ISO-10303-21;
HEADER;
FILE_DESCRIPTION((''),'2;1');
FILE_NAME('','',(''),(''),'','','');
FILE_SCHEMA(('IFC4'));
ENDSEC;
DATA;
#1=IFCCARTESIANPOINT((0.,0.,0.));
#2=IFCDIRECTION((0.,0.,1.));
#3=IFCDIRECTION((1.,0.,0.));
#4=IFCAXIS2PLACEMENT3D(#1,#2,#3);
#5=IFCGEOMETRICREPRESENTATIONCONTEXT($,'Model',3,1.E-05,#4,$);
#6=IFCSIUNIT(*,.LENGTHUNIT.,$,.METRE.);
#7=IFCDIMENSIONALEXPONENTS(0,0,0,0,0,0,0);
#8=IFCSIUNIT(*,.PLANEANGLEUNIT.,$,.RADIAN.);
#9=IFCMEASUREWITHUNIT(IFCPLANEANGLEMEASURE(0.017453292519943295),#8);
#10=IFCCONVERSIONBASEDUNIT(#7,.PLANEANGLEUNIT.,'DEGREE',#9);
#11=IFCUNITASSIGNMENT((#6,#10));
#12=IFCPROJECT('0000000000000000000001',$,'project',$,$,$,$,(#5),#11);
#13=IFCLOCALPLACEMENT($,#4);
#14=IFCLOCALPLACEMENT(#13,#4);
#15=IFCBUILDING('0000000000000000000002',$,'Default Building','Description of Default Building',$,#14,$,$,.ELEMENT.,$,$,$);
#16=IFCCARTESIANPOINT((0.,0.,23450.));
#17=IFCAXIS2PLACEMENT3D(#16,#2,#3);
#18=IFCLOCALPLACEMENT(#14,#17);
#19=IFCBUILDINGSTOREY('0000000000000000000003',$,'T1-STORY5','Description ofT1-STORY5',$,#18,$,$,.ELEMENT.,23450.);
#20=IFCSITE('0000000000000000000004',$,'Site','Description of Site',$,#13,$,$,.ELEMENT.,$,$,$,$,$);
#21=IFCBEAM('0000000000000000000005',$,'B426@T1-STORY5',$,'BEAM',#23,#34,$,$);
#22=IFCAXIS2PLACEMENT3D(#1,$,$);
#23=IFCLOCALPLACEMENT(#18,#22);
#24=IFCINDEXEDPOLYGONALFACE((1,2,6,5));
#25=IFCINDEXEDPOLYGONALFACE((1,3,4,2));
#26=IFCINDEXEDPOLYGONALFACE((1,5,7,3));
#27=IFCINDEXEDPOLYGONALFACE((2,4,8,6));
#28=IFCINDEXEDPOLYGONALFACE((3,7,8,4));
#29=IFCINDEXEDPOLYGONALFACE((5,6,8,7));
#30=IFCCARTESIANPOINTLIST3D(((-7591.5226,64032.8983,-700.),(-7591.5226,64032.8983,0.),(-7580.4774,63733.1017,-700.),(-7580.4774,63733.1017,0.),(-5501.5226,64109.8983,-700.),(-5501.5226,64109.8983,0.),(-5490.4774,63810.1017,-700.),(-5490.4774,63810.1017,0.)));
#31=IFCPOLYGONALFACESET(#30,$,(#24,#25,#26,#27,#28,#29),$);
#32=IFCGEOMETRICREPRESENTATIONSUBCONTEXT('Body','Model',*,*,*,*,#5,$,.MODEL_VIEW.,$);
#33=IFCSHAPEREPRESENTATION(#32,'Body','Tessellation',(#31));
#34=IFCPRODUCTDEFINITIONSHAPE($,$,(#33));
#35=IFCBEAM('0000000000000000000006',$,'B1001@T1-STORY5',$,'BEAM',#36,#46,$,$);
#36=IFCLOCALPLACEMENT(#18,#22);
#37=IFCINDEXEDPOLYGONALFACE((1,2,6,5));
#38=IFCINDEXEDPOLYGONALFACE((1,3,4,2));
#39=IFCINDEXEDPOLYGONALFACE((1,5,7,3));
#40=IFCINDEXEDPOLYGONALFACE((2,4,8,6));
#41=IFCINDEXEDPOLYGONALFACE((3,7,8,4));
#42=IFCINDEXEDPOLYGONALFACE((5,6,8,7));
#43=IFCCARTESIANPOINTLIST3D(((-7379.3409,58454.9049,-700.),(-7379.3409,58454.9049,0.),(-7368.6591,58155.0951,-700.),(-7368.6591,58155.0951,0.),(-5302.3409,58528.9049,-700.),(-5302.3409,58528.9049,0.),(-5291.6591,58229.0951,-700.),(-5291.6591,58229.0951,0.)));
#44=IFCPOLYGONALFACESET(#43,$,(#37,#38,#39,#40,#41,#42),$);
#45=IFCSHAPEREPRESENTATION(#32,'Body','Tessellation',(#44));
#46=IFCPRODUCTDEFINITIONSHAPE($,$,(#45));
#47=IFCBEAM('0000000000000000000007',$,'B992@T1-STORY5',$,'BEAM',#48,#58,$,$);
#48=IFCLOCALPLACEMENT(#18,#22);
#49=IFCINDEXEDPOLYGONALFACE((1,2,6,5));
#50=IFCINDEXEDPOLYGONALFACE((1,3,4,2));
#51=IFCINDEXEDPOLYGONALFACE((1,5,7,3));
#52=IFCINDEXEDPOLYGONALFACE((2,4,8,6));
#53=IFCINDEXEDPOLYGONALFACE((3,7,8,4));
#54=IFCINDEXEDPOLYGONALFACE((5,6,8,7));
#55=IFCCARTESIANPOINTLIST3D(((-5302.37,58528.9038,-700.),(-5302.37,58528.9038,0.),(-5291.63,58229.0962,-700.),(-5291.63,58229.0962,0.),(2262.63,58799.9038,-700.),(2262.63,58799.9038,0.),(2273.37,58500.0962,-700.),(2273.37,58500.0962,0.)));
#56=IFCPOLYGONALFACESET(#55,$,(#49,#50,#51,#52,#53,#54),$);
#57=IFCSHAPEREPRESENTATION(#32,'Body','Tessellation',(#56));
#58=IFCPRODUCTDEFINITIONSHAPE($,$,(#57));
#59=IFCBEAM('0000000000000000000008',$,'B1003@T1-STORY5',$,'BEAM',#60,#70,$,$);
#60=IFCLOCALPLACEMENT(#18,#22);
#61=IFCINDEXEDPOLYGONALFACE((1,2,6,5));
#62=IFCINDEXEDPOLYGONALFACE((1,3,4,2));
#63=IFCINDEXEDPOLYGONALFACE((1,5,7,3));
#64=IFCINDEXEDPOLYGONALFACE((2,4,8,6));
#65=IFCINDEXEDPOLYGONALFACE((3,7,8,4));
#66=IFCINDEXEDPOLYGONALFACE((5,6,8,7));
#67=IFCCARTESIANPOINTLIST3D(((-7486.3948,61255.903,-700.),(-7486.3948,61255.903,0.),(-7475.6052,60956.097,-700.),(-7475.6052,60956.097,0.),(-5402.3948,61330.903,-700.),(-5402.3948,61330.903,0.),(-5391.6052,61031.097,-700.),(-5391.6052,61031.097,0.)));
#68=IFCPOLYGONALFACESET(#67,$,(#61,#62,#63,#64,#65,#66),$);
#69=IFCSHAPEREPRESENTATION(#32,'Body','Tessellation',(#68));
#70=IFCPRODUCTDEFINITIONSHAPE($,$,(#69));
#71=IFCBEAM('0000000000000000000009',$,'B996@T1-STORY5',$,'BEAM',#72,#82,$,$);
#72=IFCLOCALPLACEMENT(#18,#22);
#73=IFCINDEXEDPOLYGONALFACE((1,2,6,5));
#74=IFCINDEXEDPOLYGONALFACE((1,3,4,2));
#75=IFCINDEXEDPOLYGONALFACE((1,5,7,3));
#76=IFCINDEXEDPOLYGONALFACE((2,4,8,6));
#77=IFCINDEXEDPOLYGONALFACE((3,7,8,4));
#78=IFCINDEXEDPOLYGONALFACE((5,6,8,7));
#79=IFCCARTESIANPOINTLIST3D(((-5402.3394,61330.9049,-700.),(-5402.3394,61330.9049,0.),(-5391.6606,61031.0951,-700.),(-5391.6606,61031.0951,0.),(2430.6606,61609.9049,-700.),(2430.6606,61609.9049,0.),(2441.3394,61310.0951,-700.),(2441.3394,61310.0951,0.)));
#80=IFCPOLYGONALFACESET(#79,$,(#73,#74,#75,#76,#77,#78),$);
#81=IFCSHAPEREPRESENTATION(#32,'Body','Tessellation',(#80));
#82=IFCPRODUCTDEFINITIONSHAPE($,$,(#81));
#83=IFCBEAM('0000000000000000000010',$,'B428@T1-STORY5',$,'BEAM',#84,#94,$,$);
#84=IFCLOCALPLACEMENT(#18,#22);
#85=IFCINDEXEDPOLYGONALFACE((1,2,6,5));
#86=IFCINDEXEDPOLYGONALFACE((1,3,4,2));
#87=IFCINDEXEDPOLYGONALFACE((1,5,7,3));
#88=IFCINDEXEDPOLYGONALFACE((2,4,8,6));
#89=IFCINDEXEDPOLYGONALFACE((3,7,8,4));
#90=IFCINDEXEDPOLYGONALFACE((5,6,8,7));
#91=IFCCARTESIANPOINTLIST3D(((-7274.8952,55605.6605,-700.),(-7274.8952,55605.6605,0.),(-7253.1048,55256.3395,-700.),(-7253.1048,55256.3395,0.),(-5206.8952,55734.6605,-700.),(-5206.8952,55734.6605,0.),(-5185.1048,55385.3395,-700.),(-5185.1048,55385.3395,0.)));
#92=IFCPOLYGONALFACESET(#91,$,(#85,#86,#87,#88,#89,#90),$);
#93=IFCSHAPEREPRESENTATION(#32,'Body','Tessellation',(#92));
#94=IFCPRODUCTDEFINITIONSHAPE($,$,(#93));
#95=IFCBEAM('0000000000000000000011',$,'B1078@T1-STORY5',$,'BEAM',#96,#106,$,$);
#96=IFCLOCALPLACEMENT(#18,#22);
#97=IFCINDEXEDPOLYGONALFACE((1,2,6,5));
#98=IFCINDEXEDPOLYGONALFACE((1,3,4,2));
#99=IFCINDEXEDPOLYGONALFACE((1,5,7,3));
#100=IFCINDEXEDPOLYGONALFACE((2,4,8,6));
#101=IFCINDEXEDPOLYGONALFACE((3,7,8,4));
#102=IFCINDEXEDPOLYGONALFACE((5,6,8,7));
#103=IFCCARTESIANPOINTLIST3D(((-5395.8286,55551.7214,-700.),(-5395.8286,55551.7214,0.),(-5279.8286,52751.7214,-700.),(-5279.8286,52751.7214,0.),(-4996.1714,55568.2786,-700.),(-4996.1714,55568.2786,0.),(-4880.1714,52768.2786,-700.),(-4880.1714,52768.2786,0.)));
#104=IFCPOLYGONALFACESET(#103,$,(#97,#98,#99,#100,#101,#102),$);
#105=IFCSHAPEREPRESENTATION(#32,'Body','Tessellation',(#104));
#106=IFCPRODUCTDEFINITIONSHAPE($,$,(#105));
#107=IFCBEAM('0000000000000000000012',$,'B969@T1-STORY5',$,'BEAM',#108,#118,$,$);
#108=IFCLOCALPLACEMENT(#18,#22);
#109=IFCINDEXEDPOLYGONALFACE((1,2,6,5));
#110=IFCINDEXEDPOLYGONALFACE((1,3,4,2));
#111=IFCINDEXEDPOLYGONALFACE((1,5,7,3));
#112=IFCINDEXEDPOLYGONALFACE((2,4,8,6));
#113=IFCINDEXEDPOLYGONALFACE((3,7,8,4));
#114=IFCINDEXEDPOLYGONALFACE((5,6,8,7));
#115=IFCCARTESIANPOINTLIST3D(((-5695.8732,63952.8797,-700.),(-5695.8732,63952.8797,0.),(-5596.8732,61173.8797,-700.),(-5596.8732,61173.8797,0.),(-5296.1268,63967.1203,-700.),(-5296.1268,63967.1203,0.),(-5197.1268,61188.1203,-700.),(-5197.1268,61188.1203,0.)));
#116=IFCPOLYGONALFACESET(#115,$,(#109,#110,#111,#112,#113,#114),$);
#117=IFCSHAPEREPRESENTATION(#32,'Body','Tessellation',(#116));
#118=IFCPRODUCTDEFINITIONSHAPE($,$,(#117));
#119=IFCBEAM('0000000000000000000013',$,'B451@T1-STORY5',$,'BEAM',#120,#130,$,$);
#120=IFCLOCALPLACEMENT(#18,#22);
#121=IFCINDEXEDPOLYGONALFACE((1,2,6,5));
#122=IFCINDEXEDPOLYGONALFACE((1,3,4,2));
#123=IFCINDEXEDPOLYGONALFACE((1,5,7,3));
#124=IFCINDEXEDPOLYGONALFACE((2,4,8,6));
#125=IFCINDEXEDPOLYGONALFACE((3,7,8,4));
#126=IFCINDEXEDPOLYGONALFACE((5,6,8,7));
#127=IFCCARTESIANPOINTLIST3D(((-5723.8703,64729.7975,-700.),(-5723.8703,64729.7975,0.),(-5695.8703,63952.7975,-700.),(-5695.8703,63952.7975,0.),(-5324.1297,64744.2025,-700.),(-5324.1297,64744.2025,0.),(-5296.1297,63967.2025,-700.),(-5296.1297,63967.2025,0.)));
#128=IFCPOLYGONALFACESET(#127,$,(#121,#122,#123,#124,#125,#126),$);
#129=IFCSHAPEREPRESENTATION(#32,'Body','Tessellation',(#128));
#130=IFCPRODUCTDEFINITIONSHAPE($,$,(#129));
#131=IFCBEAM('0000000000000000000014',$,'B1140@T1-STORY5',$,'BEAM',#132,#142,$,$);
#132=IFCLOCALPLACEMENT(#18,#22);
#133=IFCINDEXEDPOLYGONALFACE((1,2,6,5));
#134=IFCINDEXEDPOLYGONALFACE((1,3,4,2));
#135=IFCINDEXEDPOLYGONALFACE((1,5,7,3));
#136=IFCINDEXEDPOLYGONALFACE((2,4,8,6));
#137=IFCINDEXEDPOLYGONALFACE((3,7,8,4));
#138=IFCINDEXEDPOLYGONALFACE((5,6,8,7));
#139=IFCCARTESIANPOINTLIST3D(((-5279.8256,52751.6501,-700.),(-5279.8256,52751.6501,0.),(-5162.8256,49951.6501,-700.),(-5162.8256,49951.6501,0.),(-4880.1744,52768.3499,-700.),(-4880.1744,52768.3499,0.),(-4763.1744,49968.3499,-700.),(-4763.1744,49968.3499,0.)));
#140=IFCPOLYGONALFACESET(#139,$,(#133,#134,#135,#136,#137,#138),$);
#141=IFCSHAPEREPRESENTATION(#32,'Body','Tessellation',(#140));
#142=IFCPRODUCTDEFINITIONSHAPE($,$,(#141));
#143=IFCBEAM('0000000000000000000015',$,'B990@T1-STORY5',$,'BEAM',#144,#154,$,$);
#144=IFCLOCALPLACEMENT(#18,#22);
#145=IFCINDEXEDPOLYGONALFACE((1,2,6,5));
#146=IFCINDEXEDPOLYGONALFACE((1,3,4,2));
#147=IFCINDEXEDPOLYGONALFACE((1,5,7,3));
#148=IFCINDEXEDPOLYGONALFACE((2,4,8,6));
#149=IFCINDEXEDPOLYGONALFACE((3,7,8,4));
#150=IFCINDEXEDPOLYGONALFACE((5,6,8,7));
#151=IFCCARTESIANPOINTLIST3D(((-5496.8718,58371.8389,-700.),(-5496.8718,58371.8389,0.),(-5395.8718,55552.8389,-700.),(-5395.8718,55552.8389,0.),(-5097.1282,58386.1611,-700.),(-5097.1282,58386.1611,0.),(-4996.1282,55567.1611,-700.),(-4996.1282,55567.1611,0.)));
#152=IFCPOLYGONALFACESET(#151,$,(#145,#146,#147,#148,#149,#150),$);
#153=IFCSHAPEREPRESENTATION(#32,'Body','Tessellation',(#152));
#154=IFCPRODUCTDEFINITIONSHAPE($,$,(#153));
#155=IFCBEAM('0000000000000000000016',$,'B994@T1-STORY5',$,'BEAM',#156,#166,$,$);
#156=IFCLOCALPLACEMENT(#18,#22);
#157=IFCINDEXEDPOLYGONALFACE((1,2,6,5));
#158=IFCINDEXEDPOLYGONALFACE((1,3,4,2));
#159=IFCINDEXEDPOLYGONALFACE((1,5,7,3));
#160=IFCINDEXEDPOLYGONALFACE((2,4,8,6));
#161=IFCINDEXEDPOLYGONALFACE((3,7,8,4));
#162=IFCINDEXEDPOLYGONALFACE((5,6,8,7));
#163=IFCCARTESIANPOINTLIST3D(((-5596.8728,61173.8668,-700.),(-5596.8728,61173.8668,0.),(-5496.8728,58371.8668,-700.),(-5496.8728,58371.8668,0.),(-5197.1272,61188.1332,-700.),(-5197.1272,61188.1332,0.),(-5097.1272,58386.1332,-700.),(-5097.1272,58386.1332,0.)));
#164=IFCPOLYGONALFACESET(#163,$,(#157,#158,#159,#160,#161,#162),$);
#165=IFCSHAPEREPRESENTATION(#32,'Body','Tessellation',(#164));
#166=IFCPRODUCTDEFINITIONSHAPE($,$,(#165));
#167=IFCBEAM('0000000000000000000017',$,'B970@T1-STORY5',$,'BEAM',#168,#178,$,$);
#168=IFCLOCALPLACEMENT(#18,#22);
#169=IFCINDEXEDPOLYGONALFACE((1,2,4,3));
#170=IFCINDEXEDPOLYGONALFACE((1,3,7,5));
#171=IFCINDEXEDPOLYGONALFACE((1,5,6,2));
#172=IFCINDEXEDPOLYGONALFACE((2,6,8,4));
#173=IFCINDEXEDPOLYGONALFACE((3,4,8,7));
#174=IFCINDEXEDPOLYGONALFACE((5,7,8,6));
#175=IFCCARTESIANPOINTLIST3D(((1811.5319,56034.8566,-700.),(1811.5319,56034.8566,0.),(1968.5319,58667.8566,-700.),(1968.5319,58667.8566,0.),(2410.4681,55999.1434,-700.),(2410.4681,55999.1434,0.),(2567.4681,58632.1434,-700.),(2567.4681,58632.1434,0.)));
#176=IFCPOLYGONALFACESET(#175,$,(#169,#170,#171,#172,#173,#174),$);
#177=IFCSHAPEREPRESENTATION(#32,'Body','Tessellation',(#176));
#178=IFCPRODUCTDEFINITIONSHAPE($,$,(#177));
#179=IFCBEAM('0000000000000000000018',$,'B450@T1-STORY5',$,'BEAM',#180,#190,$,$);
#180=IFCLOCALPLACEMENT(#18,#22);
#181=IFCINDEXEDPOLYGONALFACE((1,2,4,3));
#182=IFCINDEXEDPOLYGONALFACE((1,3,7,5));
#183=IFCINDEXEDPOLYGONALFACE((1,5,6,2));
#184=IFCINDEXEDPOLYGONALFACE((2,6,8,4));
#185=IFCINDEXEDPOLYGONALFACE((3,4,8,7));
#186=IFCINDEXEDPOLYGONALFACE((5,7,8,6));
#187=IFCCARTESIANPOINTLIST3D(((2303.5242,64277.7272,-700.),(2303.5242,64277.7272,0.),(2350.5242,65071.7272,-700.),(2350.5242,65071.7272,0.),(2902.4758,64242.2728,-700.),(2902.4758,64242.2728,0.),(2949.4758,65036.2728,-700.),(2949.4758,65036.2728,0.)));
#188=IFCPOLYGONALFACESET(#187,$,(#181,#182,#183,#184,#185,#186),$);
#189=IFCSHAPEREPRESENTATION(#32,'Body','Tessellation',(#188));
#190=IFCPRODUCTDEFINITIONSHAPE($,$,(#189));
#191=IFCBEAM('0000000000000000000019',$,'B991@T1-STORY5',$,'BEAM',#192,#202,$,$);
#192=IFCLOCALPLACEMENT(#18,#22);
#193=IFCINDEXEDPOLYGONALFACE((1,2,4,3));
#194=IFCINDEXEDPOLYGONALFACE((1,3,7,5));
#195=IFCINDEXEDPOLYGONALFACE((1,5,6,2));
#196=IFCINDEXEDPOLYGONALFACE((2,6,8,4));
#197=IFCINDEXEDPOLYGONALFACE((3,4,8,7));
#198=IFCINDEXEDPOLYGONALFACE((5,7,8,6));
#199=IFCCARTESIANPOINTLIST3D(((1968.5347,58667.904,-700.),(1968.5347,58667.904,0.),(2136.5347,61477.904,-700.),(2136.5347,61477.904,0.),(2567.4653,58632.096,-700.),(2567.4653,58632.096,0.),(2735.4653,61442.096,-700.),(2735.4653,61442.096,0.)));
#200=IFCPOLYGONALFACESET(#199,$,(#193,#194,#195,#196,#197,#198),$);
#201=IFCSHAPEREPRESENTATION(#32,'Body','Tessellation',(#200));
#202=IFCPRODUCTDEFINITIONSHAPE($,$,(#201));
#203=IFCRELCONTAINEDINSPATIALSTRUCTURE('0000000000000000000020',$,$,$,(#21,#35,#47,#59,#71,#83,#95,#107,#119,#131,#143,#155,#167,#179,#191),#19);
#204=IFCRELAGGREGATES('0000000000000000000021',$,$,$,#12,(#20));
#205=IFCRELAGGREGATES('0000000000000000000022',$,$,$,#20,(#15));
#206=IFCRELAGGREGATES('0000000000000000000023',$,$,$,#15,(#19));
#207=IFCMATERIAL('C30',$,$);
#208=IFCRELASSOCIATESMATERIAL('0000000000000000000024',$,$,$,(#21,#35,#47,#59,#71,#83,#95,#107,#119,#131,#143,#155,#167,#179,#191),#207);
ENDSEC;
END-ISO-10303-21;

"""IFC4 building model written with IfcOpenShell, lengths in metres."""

from ifc_helpers import new_model, entity, si_unit, converted_unit, frame, origin_with_axes, place, context, subcontext, project, spatial, rectangle, extrude, material, element, save


model = new_model("IFC4")

# Units and contexts
model_context = context("Model", 3, precision=1e-05, world=origin_with_axes())
body_context = subcontext(model_context, "Body", "Model", "MODEL_VIEW")
ifc_project = project(units=[si_unit("LENGTHUNIT", "METRE"), converted_unit("PLANEANGLEUNIT", "DEGREE", entity("IfcPlaneAngleMeasure", 0.017453292519943295), si_unit("PLANEANGLEUNIT", "RADIAN"), dimensions=[0, 0, 0, 0, 0, 0, 0])], contexts=[model_context])

# Site, building, storey
site_placement = place(None, origin_with_axes())
site = spatial("IfcSite", under=ifc_project, at=site_placement, Name="Site", Description="Description of Site", CompositionType="ELEMENT")
building_placement = place(site_placement, origin_with_axes())
building = spatial("IfcBuilding", under=site, at=building_placement, Name="Default Building", Description="Description of Default Building", CompositionType="ELEMENT")
storey_placement = place(building_placement, frame((0.0, 0.0, 23450.0), z_axis=(0.0, 0.0, 1.0), x_axis=(1.0, 0.0, 0.0)))
storey = spatial("IfcBuildingStorey", under=building, at=storey_placement, Name="T1-STORY5", Description="Description ofT1-STORY5", CompositionType="ELEMENT", Elevation=23450.0)

# Beams
ifc_material_1 = material(Name="C30")
beam_1_placement = place(storey_placement, frame((-7586.0, 63883.0, -350.0), z_axis=(0.999322, 0.036817, 0.0), x_axis=(-0.036817, 0.999322, 0.0)))
element("IfcBeam", 1, at=beam_1_placement, inside=storey, material=ifc_material_1, Name="B426@T1-STORY5", ObjectType="BEAM", context=body_context, shape_type="SweptSolid", body=[
    extrude(rectangle(XDim=300.0, YDim=700.0), origin_with_axes(), (0.0, 0.0, 1.0), 2091.4179),
])
beam_2_placement = place(storey_placement, frame((-7374.0, 58305.0, -350.0), z_axis=(0.999366, 0.035606, 0.0), x_axis=(-0.035606, 0.999366, 0.0)))
element("IfcBeam", 2, at=beam_2_placement, inside=storey, material=ifc_material_1, Name="B1001@T1-STORY5", ObjectType="BEAM", context=body_context, shape_type="SweptSolid", body=[
    extrude(rectangle(XDim=300.0, YDim=700.0), origin_with_axes(), (0.0, 0.0, 1.0), 2078.3178),
])
beam_3_placement = place(storey_placement, frame((-5297.0, 58379.0, -350.0), z_axis=(0.999359, 0.0358, 0.0), x_axis=(-0.0358, 0.999359, 0.0)))
element("IfcBeam", 3, at=beam_3_placement, inside=storey, material=ifc_material_1, Name="B992@T1-STORY5", ObjectType="BEAM", context=body_context, shape_type="SweptSolid", body=[
    extrude(rectangle(XDim=300.0, YDim=700.0), origin_with_axes(), (0.0, 0.0, 1.0), 7569.8524),
])
beam_4_placement = place(storey_placement, frame((-7481.0, 61106.0, -350.0), z_axis=(0.999353, 0.035965, 0.0), x_axis=(-0.035965, 0.999353, 0.0)))
element("IfcBeam", 4, at=beam_4_placement, inside=storey, material=ifc_material_1, Name="B1003@T1-STORY5", ObjectType="BEAM", context=body_context, shape_type="SweptSolid", body=[
    extrude(rectangle(XDim=300.0, YDim=700.0), origin_with_axes(), (0.0, 0.0, 1.0), 2085.3491),
])
beam_5_placement = place(storey_placement, frame((-5397.0, 61181.0, -350.0), z_axis=(0.999366, 0.035596, 0.0), x_axis=(-0.035596, 0.999366, 0.0)))
element("IfcBeam", 5, at=beam_5_placement, inside=storey, material=ifc_material_1, Name="B996@T1-STORY5", ObjectType="BEAM", context=body_context, shape_type="SweptSolid", body=[
    extrude(rectangle(XDim=300.0, YDim=700.0), origin_with_axes(), (0.0, 0.0, 1.0), 7837.9672),
])
beam_6_placement = place(storey_placement, frame((-7264.0, 55431.0, -350.0), z_axis=(0.99806, 0.062258, 0.0), x_axis=(-0.062258, 0.99806, 0.0)))
element("IfcBeam", 6, at=beam_6_placement, inside=storey, material=ifc_material_1, Name="B428@T1-STORY5", ObjectType="BEAM", context=body_context, shape_type="SweptSolid", body=[
    extrude(rectangle(XDim=350.0, YDim=700.0), origin_with_axes(), (0.0, 0.0, 1.0), 2072.0195),
])
beam_7_placement = place(storey_placement, frame((-5196.0, 55560.0, -350.0), z_axis=(0.041393, -0.999143, 0.0), x_axis=(0.999143, 0.041393, 0.0)))
element("IfcBeam", 7, at=beam_7_placement, inside=storey, material=ifc_material_1, Name="B1078@T1-STORY5", ObjectType="BEAM", context=body_context, shape_type="SweptSolid", body=[
    extrude(rectangle(XDim=400.0, YDim=700.0), origin_with_axes(), (0.0, 0.0, 1.0), 2802.4018),
])
beam_8_placement = place(storey_placement, frame((-5496.0, 63960.0, -350.0), z_axis=(0.035602, -0.999366, 0.0), x_axis=(0.999366, 0.035602, 0.0)))
element("IfcBeam", 8, at=beam_8_placement, inside=storey, material=ifc_material_1, Name="B969@T1-STORY5", ObjectType="BEAM", context=body_context, shape_type="SweptSolid", body=[
    extrude(rectangle(XDim=400.0, YDim=700.0), origin_with_axes(), (0.0, 0.0, 1.0), 2780.7628),
])
beam_9_placement = place(storey_placement, frame((-5524.0, 64737.0, -350.0), z_axis=(0.036013, -0.999351, 0.0), x_axis=(0.999351, 0.036013, 0.0)))
element("IfcBeam", 9, at=beam_9_placement, inside=storey, material=ifc_material_1, Name="B451@T1-STORY5", ObjectType="BEAM", context=body_context, shape_type="SweptSolid", body=[
    extrude(rectangle(XDim=400.0, YDim=700.0), origin_with_axes(), (0.0, 0.0, 1.0), 777.5043),
])
beam_10_placement = place(storey_placement, frame((-5080.0, 52760.0, -350.0), z_axis=(0.041749, -0.999128, 0.0), x_axis=(0.999128, 0.041749, 0.0)))
element("IfcBeam", 10, at=beam_10_placement, inside=storey, material=ifc_material_1, Name="B1140@T1-STORY5", ObjectType="BEAM", context=body_context, shape_type="SweptSolid", body=[
    extrude(rectangle(XDim=400.0, YDim=700.0), origin_with_axes(), (0.0, 0.0, 1.0), 2802.4434),
])
beam_11_placement = place(storey_placement, frame((-5297.0, 58379.0, -350.0), z_axis=(0.035805, -0.999359, 0.0), x_axis=(0.999359, 0.035805, 0.0)))
element("IfcBeam", 11, at=beam_11_placement, inside=storey, material=ifc_material_1, Name="B990@T1-STORY5", ObjectType="BEAM", context=body_context, shape_type="SweptSolid", body=[
    extrude(rectangle(XDim=400.0, YDim=700.0), origin_with_axes(), (0.0, 0.0, 1.0), 2820.8087),
])
beam_12_placement = place(storey_placement, frame((-5397.0, 61181.0, -350.0), z_axis=(0.035666, -0.999364, 0.0), x_axis=(0.999364, 0.035666, 0.0)))
element("IfcBeam", 12, at=beam_12_placement, inside=storey, material=ifc_material_1, Name="B994@T1-STORY5", ObjectType="BEAM", context=body_context, shape_type="SweptSolid", body=[
    extrude(rectangle(XDim=400.0, YDim=700.0), origin_with_axes(), (0.0, 0.0, 1.0), 2803.7839),
])
beam_13_placement = place(storey_placement, frame((2111.0, 56017.0, -350.0), z_axis=(0.059522, 0.998227, 0.0), x_axis=(-0.998227, 0.059522, 0.0)))
element("IfcBeam", 13, at=beam_13_placement, inside=storey, material=ifc_material_1, Name="B970@T1-STORY5", ObjectType="BEAM", context=body_context, shape_type="SweptSolid", body=[
    extrude(rectangle(XDim=600.0, YDim=700.0), origin_with_axes(), (0.0, 0.0, 1.0), 2637.6766),
])
beam_14_placement = place(storey_placement, frame((2603.0, 64260.0, -350.0), z_axis=(0.059091, 0.998253, 0.0), x_axis=(-0.998253, 0.059091, 0.0)))
element("IfcBeam", 14, at=beam_14_placement, inside=storey, material=ifc_material_1, Name="B450@T1-STORY5", ObjectType="BEAM", context=body_context, shape_type="SweptSolid", body=[
    extrude(rectangle(XDim=600.0, YDim=700.0), origin_with_axes(), (0.0, 0.0, 1.0), 795.3898),
])
beam_15_placement = place(storey_placement, frame((2268.0, 58650.0, -350.0), z_axis=(0.05968, 0.998218, 0.0), x_axis=(-0.998218, 0.05968, 0.0)))
element("IfcBeam", 15, at=beam_15_placement, inside=storey, material=ifc_material_1, Name="B991@T1-STORY5", ObjectType="BEAM", context=body_context, shape_type="SweptSolid", body=[
    extrude(rectangle(XDim=600.0, YDim=700.0), origin_with_axes(), (0.0, 0.0, 1.0), 2815.0176),
])

save(model, "model.ifc")
